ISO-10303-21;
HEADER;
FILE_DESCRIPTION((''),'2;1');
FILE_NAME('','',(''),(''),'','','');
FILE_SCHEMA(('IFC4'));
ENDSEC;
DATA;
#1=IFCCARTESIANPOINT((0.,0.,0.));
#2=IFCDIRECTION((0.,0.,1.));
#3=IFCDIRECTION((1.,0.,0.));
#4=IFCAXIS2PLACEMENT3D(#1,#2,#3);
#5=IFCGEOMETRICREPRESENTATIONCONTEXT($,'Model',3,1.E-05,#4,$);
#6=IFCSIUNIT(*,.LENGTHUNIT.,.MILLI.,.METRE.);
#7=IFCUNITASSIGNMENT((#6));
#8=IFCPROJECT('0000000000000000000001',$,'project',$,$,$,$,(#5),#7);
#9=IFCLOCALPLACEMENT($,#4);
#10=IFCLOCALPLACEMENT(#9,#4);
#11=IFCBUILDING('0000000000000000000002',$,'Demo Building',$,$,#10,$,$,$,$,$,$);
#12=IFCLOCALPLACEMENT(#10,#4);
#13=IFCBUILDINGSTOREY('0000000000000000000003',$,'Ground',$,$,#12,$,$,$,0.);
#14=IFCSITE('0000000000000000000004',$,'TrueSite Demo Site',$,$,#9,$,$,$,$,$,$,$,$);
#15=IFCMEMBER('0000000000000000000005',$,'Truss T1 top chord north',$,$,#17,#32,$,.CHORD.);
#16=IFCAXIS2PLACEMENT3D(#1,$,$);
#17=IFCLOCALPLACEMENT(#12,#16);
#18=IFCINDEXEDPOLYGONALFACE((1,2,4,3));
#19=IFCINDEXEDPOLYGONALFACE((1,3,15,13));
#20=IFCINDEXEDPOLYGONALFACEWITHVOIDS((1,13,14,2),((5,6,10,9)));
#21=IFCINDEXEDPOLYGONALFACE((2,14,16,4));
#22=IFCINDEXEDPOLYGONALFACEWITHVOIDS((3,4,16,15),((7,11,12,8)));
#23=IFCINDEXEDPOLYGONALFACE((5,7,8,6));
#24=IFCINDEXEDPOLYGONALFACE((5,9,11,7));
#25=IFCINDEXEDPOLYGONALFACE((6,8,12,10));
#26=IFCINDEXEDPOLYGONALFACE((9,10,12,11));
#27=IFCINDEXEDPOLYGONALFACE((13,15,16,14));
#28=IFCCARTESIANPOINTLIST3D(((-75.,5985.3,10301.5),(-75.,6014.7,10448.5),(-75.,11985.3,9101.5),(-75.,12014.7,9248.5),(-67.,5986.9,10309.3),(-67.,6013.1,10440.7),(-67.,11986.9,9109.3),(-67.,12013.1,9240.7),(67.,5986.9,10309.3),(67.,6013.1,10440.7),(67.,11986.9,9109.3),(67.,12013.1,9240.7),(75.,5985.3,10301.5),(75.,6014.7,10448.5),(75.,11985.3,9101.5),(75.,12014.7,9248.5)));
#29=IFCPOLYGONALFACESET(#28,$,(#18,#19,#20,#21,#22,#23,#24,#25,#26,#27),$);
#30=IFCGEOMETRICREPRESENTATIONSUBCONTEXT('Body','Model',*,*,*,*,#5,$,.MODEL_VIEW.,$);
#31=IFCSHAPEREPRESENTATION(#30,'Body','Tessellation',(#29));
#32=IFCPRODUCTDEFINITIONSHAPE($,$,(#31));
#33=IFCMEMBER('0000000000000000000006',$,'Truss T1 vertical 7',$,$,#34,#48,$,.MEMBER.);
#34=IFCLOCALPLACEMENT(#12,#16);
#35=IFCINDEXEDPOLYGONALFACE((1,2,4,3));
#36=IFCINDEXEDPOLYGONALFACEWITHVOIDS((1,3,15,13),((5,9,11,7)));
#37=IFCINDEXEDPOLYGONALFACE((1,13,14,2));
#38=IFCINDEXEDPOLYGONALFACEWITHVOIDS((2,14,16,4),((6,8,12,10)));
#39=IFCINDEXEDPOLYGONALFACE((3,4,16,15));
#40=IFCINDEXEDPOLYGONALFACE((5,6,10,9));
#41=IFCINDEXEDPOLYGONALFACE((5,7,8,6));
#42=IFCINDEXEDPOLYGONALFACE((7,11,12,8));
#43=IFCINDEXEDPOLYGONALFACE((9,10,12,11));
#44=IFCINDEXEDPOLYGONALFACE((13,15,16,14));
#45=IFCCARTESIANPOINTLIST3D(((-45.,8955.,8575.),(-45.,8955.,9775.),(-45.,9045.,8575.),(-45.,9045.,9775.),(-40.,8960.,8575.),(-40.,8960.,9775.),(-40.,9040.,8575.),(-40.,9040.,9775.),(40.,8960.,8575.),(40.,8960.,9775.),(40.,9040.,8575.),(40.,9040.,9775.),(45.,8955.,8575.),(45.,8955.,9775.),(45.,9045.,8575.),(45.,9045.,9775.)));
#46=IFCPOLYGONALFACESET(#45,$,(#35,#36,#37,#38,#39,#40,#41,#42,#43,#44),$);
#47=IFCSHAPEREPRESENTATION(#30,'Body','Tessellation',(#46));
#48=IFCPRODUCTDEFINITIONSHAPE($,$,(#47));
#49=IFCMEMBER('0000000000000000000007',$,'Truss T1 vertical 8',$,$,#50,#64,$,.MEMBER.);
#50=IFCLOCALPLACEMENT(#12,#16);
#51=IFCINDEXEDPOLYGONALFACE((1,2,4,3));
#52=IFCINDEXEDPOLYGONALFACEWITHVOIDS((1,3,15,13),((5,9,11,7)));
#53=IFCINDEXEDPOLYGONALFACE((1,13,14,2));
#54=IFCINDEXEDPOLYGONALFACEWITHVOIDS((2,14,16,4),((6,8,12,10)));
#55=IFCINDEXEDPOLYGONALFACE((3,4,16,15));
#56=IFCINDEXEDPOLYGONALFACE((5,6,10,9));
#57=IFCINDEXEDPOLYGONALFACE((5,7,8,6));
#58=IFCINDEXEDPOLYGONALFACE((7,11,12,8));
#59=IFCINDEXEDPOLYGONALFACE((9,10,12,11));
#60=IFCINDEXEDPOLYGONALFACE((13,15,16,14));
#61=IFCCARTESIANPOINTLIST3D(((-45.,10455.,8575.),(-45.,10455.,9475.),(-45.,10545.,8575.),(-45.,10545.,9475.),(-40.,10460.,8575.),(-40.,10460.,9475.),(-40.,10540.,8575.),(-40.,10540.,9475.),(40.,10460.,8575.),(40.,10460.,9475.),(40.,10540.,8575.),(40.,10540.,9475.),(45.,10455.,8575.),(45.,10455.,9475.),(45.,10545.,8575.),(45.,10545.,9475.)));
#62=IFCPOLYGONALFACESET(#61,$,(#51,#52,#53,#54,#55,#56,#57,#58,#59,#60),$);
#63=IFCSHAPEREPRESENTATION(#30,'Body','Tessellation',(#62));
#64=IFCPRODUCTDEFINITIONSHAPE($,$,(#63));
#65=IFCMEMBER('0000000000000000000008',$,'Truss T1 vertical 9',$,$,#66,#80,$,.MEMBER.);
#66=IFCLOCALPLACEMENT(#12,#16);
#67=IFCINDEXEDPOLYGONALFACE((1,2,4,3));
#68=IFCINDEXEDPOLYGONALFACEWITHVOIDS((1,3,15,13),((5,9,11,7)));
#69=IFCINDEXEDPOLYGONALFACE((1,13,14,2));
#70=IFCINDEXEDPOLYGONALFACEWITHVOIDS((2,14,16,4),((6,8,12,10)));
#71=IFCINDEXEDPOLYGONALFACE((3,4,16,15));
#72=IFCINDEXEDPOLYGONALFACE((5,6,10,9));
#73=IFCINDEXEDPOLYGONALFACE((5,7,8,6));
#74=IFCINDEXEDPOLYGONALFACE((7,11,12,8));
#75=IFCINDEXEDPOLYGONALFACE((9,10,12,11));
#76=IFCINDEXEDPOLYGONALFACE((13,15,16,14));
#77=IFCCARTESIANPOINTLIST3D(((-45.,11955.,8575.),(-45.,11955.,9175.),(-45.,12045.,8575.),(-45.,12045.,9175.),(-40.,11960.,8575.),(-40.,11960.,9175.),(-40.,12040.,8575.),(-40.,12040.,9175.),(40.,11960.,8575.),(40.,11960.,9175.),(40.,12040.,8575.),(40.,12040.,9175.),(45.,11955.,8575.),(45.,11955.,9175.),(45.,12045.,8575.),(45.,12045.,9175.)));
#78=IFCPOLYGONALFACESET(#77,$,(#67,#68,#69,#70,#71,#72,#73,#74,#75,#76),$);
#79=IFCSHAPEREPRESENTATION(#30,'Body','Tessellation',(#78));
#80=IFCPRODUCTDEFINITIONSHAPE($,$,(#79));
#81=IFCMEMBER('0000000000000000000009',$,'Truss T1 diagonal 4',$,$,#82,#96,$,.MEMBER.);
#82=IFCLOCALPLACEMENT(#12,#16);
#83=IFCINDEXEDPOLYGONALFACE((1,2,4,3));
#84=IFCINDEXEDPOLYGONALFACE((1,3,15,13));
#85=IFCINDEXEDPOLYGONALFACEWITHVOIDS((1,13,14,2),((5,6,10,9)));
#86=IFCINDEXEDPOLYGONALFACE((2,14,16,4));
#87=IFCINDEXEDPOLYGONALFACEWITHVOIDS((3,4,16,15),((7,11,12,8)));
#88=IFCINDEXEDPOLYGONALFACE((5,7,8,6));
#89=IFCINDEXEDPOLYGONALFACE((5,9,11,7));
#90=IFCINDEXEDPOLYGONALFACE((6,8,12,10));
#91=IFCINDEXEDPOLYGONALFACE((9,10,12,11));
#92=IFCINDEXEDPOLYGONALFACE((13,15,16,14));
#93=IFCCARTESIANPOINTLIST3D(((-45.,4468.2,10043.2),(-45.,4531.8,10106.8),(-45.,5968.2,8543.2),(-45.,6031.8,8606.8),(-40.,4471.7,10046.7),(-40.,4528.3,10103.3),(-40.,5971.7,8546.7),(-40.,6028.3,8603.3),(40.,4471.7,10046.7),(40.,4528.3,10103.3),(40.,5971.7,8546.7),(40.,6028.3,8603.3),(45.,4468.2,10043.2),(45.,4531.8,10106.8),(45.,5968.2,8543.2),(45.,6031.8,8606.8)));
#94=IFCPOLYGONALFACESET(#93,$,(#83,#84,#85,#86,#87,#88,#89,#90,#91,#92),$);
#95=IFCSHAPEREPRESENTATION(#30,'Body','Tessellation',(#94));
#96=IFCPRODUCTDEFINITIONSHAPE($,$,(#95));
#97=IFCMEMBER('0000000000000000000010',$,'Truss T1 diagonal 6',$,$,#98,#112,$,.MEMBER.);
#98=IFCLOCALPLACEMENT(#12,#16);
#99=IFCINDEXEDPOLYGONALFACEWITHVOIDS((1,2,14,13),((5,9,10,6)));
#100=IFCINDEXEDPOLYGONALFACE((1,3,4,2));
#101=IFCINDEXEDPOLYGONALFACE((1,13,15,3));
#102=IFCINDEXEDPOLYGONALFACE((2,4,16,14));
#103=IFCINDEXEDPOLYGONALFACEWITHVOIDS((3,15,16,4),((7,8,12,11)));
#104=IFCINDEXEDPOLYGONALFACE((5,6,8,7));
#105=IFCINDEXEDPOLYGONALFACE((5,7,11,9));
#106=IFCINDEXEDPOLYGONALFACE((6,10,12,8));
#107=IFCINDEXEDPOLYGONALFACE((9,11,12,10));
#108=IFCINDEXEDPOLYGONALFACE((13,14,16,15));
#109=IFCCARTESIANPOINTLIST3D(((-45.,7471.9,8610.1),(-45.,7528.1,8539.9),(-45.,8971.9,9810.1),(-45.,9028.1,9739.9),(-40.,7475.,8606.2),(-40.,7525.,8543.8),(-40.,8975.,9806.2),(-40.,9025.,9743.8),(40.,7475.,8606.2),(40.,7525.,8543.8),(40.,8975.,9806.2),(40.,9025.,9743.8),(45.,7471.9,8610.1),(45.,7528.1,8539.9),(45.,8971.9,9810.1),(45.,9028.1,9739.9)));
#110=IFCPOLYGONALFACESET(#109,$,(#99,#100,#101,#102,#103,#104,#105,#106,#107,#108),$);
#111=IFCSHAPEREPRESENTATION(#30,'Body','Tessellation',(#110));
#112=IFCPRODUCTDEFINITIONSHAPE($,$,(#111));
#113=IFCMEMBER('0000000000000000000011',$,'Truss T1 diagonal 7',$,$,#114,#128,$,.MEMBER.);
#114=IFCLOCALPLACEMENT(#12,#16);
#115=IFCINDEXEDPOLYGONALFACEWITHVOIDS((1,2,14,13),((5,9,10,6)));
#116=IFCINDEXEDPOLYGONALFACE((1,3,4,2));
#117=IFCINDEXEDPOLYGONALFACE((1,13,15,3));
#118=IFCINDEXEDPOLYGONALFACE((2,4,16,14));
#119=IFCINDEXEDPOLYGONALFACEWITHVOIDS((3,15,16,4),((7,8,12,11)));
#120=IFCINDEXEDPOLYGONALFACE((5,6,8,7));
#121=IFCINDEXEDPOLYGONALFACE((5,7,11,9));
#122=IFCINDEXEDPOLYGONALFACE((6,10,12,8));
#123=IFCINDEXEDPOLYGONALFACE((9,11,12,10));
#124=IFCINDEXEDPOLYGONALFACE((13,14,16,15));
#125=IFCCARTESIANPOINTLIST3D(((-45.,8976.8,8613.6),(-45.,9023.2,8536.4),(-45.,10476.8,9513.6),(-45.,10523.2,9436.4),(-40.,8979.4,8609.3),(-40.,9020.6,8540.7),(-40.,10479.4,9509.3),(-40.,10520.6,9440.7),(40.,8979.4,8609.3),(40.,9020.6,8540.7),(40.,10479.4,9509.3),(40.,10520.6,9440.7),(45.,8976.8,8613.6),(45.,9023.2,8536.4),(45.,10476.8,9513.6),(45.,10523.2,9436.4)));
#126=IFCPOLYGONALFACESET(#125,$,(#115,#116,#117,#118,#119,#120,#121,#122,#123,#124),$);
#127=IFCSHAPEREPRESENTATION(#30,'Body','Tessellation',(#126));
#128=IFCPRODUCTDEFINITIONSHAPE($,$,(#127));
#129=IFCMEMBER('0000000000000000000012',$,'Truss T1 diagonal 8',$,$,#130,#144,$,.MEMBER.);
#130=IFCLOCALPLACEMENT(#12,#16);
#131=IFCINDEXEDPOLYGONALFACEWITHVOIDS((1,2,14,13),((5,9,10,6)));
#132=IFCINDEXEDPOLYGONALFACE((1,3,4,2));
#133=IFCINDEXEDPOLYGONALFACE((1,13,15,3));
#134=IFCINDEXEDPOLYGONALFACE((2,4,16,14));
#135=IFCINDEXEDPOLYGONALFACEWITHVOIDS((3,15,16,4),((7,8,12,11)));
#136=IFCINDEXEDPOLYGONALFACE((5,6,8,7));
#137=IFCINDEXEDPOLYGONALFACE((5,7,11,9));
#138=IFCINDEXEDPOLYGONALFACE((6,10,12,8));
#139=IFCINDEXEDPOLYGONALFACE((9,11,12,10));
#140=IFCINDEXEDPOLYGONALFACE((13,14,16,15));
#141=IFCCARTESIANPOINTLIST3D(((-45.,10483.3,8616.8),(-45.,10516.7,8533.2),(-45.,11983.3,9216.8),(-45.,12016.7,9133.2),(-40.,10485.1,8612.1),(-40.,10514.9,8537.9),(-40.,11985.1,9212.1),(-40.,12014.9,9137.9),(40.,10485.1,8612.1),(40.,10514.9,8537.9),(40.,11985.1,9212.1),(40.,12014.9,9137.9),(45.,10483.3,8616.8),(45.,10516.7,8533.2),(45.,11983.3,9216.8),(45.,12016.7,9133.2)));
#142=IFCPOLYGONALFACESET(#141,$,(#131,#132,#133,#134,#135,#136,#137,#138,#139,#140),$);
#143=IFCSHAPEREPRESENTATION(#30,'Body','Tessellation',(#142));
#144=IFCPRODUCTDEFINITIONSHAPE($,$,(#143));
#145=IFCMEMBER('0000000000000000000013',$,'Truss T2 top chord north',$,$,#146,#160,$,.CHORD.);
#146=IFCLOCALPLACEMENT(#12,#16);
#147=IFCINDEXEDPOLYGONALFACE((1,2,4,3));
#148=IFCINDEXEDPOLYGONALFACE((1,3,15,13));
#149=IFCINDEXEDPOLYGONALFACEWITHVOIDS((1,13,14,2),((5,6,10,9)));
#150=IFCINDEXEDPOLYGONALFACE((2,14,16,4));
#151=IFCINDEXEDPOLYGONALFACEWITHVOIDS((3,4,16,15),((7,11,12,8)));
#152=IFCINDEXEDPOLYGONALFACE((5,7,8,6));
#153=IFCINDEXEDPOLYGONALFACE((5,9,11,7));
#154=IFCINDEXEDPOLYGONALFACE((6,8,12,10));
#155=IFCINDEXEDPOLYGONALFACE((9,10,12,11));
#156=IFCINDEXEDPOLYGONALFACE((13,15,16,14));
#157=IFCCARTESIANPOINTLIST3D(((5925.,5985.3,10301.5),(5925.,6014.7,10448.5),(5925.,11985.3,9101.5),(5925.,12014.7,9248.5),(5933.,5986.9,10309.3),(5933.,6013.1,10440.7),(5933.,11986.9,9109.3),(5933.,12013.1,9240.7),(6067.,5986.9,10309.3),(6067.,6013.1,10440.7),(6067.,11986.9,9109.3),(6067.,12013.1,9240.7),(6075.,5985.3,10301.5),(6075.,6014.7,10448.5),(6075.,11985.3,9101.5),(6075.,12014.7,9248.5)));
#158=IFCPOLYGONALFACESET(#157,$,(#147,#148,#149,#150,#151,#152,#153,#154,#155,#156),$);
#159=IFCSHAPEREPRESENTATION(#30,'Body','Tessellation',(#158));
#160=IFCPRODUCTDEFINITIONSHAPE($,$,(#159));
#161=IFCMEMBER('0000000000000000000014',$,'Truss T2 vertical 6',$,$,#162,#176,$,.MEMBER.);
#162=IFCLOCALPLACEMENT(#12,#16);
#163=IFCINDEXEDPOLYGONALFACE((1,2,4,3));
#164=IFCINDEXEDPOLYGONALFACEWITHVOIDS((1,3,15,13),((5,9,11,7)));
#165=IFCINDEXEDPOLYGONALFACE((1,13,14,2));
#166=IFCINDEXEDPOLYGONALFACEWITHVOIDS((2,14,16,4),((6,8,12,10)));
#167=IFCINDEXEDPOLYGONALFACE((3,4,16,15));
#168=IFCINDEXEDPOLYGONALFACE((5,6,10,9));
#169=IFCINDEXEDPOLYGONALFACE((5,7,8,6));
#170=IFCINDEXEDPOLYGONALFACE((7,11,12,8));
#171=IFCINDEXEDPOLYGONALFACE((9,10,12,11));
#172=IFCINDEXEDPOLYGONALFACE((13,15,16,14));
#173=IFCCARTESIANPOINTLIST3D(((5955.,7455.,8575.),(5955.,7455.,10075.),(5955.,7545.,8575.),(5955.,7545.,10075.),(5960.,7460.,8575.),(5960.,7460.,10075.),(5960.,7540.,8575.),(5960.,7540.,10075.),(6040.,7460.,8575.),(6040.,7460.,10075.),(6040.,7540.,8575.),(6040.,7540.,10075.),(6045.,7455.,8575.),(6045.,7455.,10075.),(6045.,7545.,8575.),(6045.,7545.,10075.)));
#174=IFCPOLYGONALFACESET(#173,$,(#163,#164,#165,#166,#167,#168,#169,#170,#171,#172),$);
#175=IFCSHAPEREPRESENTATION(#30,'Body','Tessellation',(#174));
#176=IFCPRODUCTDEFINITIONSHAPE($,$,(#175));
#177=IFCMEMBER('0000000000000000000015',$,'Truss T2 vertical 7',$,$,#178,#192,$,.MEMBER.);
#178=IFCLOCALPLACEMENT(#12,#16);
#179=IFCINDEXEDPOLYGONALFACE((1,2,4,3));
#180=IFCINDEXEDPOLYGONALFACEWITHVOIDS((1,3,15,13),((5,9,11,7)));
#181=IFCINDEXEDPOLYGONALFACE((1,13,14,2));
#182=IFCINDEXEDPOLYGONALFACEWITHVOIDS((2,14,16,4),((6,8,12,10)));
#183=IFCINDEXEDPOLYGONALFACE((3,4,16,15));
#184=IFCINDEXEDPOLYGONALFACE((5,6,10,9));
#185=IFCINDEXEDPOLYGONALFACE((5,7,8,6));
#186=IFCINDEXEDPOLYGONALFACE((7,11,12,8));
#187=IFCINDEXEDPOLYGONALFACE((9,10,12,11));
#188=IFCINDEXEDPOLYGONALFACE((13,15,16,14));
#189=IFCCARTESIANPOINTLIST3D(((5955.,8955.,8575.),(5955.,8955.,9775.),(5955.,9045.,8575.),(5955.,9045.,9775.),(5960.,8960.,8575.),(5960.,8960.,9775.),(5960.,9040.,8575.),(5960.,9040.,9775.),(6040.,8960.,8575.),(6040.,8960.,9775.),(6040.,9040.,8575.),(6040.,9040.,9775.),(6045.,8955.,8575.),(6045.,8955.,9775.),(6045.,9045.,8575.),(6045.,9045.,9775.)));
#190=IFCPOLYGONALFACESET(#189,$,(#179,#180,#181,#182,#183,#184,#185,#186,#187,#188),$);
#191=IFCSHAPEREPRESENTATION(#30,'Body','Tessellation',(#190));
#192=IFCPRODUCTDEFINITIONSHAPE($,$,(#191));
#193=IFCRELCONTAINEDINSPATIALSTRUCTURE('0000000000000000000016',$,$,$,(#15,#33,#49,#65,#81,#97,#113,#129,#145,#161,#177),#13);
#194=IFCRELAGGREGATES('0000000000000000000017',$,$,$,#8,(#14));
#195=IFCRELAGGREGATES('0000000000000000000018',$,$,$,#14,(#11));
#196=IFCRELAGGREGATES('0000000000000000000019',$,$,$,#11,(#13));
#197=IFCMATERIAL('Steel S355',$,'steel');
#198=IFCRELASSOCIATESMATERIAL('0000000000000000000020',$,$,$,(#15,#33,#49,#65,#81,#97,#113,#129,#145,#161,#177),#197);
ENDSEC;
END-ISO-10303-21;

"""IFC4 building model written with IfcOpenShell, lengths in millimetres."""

from ifc_helpers import new_model, si_unit, frame, origin_with_axes, place, context, subcontext, project, spatial, hollow_rectangle, extrude, material, element, save


model = new_model("IFC4")

# Units and contexts
model_context = context("Model", 3, precision=1e-05, world=origin_with_axes())
body_context = subcontext(model_context, "Body", "Model", "MODEL_VIEW")
ifc_project = project(units=[si_unit("LENGTHUNIT", "METRE", prefix="MILLI")], contexts=[model_context])

# Site, building, storey
site_placement = place(None, origin_with_axes())
site = spatial("IfcSite", under=ifc_project, at=site_placement, Name="TrueSite Demo Site")
building_placement = place(site_placement, origin_with_axes())
building = spatial("IfcBuilding", under=site, at=building_placement, Name="Demo Building")
storey_placement = place(building_placement, origin_with_axes())
storey = spatial("IfcBuildingStorey", under=building, at=storey_placement, Name="Ground", Elevation=0.0)

# Members
ifc_material = material(Name="Steel S355", Category="steel")
member_1_placement = place(storey_placement, frame((0.0, 6000.0, 10375.0), z_axis=(0.0, 0.980581, -0.196116), x_axis=(-1.0, 0.0, 0.0)))
element("IfcMember", 1, at=member_1_placement, inside=storey, material=ifc_material, Name="Truss T1 top chord north", PredefinedType="CHORD", context=body_context, shape_type="SweptSolid", body=[
    extrude(hollow_rectangle(XDim=150.0, YDim=150.0, WallThickness=8.0), origin_with_axes(), (0.0, 0.0, 1.0), 6118.8),
])
member_2_placement = place(storey_placement, frame((0.0, 9000.0, 8575.0), z_axis=(0.0, 0.0, 1.0), x_axis=(1.0, 0.0, 0.0)))
element("IfcMember", 2, at=member_2_placement, inside=storey, material=ifc_material, Name="Truss T1 vertical 7", PredefinedType="MEMBER", context=body_context, shape_type="SweptSolid", body=[
    extrude(hollow_rectangle(XDim=90.0, YDim=90.0, WallThickness=5.0), origin_with_axes(), (0.0, 0.0, 1.0), 1200.0),
])
member_3_placement = place(storey_placement, frame((0.0, 10500.0, 8575.0), z_axis=(0.0, 0.0, 1.0), x_axis=(1.0, 0.0, 0.0)))
element("IfcMember", 3, at=member_3_placement, inside=storey, material=ifc_material, Name="Truss T1 vertical 8", PredefinedType="MEMBER", context=body_context, shape_type="SweptSolid", body=[
    extrude(hollow_rectangle(XDim=90.0, YDim=90.0, WallThickness=5.0), origin_with_axes(), (0.0, 0.0, 1.0), 900.0),
])
member_4_placement = place(storey_placement, frame((0.0, 12000.0, 8575.0), z_axis=(0.0, 0.0, 1.0), x_axis=(1.0, 0.0, 0.0)))
element("IfcMember", 4, at=member_4_placement, inside=storey, material=ifc_material, Name="Truss T1 vertical 9", PredefinedType="MEMBER", context=body_context, shape_type="SweptSolid", body=[
    extrude(hollow_rectangle(XDim=90.0, YDim=90.0, WallThickness=5.0), origin_with_axes(), (0.0, 0.0, 1.0), 600.0),
])
member_5_placement = place(storey_placement, frame((0.0, 4500.0, 10075.0), z_axis=(0.0, 0.707107, -0.707107), x_axis=(-1.0, 0.0, 0.0)))
element("IfcMember", 5, at=member_5_placement, inside=storey, material=ifc_material, Name="Truss T1 diagonal 4", PredefinedType="MEMBER", context=body_context, shape_type="SweptSolid", body=[
    extrude(hollow_rectangle(XDim=90.0, YDim=90.0, WallThickness=5.0), origin_with_axes(), (0.0, 0.0, 1.0), 2121.3),
])
member_6_placement = place(storey_placement, frame((0.0, 7500.0, 8575.0), z_axis=(0.0, 0.780869, 0.624695), x_axis=(-1.0, 0.0, 0.0)))
element("IfcMember", 6, at=member_6_placement, inside=storey, material=ifc_material, Name="Truss T1 diagonal 6", PredefinedType="MEMBER", context=body_context, shape_type="SweptSolid", body=[
    extrude(hollow_rectangle(XDim=90.0, YDim=90.0, WallThickness=5.0), origin_with_axes(), (0.0, 0.0, 1.0), 1920.9),
])
member_7_placement = place(storey_placement, frame((0.0, 9000.0, 8575.0), z_axis=(0.0, 0.857493, 0.514496), x_axis=(-1.0, 0.0, 0.0)))
element("IfcMember", 7, at=member_7_placement, inside=storey, material=ifc_material, Name="Truss T1 diagonal 7", PredefinedType="MEMBER", context=body_context, shape_type="SweptSolid", body=[
    extrude(hollow_rectangle(XDim=90.0, YDim=90.0, WallThickness=5.0), origin_with_axes(), (0.0, 0.0, 1.0), 1749.3),
])
member_8_placement = place(storey_placement, frame((0.0, 10500.0, 8575.0), z_axis=(0.0, 0.928477, 0.371391), x_axis=(-1.0, 0.0, 0.0)))
element("IfcMember", 8, at=member_8_placement, inside=storey, material=ifc_material, Name="Truss T1 diagonal 8", PredefinedType="MEMBER", context=body_context, shape_type="SweptSolid", body=[
    extrude(hollow_rectangle(XDim=90.0, YDim=90.0, WallThickness=5.0), origin_with_axes(), (0.0, 0.0, 1.0), 1615.5),
])
member_9_placement = place(storey_placement, frame((6000.0, 6000.0, 10375.0), z_axis=(0.0, 0.980581, -0.196116), x_axis=(-1.0, 0.0, 0.0)))
element("IfcMember", 9, at=member_9_placement, inside=storey, material=ifc_material, Name="Truss T2 top chord north", PredefinedType="CHORD", context=body_context, shape_type="SweptSolid", body=[
    extrude(hollow_rectangle(XDim=150.0, YDim=150.0, WallThickness=8.0), origin_with_axes(), (0.0, 0.0, 1.0), 6118.8),
])
member_10_placement = place(storey_placement, frame((6000.0, 7500.0, 8575.0), z_axis=(0.0, 0.0, 1.0), x_axis=(1.0, 0.0, 0.0)))
element("IfcMember", 10, at=member_10_placement, inside=storey, material=ifc_material, Name="Truss T2 vertical 6", PredefinedType="MEMBER", context=body_context, shape_type="SweptSolid", body=[
    extrude(hollow_rectangle(XDim=90.0, YDim=90.0, WallThickness=5.0), origin_with_axes(), (0.0, 0.0, 1.0), 1500.0),
])
member_11_placement = place(storey_placement, frame((6000.0, 9000.0, 8575.0), z_axis=(0.0, 0.0, 1.0), x_axis=(1.0, 0.0, 0.0)))
element("IfcMember", 11, at=member_11_placement, inside=storey, material=ifc_material, Name="Truss T2 vertical 7", PredefinedType="MEMBER", context=body_context, shape_type="SweptSolid", body=[
    extrude(hollow_rectangle(XDim=90.0, YDim=90.0, WallThickness=5.0), origin_with_axes(), (0.0, 0.0, 1.0), 1200.0),
])

save(model, "model.ifc")
